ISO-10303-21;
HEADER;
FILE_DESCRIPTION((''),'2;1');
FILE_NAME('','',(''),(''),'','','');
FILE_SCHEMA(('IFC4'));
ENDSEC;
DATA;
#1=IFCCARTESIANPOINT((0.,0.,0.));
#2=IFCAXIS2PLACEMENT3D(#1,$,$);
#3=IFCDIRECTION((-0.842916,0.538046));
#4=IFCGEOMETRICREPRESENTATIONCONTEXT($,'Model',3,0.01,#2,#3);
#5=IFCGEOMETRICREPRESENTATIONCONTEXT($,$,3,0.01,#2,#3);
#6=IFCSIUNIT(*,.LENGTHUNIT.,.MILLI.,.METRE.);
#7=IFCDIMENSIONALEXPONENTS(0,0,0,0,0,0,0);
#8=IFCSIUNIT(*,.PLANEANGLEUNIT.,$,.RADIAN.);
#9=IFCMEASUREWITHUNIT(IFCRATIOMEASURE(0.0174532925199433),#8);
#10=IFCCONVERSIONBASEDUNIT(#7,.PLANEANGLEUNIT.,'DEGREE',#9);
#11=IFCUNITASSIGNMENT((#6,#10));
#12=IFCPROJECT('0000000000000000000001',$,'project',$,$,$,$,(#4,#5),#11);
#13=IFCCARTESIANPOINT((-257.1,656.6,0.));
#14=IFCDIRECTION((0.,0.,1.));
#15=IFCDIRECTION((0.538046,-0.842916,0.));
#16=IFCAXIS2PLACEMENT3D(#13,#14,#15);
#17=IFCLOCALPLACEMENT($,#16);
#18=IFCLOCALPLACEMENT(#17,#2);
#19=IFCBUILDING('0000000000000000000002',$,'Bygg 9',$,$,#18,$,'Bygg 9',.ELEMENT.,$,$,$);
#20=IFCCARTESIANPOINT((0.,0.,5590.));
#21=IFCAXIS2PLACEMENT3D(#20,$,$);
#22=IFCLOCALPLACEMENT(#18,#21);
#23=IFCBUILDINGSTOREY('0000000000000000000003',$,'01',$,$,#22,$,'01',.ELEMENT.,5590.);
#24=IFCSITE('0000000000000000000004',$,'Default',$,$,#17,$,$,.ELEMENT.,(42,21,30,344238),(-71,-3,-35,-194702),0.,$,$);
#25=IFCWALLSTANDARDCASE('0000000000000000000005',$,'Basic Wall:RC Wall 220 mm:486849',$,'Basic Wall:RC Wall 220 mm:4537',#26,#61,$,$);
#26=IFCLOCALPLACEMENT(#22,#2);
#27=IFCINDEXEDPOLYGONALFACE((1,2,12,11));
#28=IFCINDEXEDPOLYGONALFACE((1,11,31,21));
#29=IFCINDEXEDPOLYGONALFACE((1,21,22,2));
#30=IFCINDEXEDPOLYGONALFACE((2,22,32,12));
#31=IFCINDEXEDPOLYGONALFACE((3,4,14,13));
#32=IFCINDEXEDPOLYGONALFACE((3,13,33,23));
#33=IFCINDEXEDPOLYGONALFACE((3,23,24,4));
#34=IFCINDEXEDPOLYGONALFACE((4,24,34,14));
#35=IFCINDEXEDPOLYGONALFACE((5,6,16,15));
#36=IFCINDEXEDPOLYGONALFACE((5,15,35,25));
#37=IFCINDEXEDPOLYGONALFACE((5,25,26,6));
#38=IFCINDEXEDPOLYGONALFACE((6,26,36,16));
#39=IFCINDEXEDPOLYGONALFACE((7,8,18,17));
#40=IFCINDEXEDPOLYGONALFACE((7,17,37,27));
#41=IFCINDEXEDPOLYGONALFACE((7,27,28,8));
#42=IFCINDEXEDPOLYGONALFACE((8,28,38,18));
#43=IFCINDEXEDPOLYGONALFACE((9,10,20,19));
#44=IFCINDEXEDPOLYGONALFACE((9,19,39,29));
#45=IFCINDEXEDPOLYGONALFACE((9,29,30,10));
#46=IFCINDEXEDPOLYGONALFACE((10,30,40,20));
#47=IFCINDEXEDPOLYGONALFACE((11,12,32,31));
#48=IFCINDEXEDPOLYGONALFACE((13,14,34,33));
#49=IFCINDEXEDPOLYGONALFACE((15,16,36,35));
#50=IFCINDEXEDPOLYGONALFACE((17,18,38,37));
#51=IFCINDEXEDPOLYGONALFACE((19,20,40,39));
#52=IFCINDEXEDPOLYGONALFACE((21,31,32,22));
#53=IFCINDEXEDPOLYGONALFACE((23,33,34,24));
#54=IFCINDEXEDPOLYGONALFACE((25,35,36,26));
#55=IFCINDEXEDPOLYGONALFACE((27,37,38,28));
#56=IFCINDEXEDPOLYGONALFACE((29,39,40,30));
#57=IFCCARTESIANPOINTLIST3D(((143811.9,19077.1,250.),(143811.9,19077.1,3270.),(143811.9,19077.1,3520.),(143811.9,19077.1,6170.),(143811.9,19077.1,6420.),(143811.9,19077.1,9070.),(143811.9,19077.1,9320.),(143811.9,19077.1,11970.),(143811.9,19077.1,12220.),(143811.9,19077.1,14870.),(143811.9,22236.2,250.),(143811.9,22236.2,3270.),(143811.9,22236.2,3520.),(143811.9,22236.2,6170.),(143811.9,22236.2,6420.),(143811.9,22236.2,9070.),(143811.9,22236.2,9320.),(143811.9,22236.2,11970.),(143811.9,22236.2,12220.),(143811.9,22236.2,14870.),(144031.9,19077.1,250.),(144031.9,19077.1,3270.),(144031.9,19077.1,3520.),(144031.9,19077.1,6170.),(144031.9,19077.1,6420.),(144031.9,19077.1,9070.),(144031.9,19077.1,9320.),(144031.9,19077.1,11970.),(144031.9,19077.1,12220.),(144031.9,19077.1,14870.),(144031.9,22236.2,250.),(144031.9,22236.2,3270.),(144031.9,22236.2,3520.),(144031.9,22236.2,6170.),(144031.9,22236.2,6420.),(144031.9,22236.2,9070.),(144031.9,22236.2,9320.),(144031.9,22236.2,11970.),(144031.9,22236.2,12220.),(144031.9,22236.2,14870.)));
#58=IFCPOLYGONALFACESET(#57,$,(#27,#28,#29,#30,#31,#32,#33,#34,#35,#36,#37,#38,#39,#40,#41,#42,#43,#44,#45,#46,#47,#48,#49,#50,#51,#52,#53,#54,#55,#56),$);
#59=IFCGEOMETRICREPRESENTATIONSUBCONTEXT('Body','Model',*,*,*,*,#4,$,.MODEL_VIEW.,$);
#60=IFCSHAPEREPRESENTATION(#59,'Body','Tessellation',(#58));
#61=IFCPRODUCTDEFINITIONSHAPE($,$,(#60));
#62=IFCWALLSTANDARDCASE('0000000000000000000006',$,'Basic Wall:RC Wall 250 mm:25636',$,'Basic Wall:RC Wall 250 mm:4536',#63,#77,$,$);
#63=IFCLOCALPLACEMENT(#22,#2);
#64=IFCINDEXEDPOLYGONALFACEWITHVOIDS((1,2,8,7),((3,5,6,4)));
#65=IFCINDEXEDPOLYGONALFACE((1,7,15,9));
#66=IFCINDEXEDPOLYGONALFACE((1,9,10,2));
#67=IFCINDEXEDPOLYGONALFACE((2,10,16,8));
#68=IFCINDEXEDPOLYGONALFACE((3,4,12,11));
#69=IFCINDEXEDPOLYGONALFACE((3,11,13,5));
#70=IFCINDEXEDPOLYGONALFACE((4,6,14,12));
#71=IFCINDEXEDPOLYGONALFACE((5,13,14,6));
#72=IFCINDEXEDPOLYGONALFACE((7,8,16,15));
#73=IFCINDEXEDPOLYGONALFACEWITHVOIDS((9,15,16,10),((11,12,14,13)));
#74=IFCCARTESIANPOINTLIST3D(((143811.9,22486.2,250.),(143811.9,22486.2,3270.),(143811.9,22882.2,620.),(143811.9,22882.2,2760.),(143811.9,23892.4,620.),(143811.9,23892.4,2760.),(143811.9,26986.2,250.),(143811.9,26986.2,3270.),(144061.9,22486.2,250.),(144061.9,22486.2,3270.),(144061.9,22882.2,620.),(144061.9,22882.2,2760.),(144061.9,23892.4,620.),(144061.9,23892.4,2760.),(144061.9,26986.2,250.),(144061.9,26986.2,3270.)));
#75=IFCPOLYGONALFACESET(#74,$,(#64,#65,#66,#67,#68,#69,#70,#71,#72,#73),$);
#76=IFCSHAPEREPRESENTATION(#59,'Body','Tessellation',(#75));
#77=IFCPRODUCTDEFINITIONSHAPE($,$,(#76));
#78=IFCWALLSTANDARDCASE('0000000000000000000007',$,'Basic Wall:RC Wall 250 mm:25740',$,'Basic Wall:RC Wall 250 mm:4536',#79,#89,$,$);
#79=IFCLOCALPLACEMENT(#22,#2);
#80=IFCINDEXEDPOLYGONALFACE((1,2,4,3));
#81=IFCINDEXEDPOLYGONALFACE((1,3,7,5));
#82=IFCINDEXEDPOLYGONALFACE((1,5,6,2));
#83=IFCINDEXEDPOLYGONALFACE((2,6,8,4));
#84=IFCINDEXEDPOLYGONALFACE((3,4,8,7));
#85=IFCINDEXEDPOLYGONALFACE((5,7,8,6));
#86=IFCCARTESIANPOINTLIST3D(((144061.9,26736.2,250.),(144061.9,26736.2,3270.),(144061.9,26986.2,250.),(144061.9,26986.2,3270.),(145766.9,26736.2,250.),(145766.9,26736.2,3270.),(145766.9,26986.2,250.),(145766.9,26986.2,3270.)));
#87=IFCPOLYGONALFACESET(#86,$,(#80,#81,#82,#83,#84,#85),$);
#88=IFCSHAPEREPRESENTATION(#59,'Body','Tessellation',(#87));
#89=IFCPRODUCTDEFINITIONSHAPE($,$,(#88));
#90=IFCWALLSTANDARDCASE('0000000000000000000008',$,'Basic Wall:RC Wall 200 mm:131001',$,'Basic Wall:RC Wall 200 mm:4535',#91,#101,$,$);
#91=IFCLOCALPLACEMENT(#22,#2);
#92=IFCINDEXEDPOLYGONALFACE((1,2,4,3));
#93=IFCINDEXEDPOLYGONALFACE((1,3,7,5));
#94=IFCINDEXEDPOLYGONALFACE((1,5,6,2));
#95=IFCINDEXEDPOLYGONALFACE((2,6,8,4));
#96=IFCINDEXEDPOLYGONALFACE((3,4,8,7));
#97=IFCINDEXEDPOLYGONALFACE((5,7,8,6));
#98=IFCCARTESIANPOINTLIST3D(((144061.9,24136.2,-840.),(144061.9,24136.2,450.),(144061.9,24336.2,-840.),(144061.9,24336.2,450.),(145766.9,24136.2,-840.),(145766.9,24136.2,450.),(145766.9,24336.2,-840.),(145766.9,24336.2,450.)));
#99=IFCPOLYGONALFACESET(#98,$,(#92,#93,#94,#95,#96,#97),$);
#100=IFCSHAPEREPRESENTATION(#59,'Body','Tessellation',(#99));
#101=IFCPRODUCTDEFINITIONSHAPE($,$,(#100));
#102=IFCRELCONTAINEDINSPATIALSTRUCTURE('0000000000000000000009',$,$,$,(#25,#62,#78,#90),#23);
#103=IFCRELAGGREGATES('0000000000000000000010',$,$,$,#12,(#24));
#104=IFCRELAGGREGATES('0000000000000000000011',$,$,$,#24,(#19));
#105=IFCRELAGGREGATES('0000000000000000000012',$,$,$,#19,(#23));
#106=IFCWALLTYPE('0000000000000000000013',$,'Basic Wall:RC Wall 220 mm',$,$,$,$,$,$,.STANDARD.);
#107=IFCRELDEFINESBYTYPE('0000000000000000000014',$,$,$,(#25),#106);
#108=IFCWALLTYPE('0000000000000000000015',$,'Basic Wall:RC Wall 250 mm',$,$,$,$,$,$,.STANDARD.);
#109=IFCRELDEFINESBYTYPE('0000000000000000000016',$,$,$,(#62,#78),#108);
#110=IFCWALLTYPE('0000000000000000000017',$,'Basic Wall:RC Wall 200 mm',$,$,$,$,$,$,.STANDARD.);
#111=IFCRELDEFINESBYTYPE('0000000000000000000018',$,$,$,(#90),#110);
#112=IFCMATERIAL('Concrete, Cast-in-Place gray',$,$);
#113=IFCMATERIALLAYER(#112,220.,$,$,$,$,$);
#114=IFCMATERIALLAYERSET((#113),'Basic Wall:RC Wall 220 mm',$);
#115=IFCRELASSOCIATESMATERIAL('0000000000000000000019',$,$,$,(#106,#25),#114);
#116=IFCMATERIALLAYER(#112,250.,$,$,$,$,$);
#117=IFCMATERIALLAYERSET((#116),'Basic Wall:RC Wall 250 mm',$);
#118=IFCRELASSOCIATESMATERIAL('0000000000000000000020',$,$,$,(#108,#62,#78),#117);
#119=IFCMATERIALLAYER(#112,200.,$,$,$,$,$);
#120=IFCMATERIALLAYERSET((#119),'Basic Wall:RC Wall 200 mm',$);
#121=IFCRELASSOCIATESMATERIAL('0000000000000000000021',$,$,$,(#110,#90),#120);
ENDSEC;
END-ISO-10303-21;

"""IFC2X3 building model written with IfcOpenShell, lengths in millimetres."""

from ifc_helpers import new_model, entity, si_unit, converted_unit, direction, frame, frame_2d, origin, origin_2d_with_axis, place, context, subcontext, project, spatial, polyline, rectangle, extrude, clip, bounded_halfspace, material, layer, layer_set, layer_usage, type_object, element, save


model = new_model("IFC2X3")

# Units and contexts
model_context = context("Model", 3, precision=0.01, world=origin(), true_north=direction((-0.842916, 0.538046)))
context_of_model = context(None, 3, precision=0.01, world=origin(), true_north=direction((-0.842916, 0.538046)))
body_context = subcontext(model_context, "Body", "Model", "MODEL_VIEW")
ifc_project = project(units=[si_unit("LENGTHUNIT", "METRE", prefix="MILLI"), converted_unit("PLANEANGLEUNIT", "DEGREE", entity("IfcRatioMeasure", 0.0174532925199433), si_unit("PLANEANGLEUNIT", "RADIAN"), dimensions=[0, 0, 0, 0, 0, 0, 0])], contexts=[model_context, context_of_model])

# Site, building, storey
site_placement = place(None, frame((-257.1, 656.6, 0.0), z_axis=(0.0, 0.0, 1.0), x_axis=(0.538046, -0.842916, 0.0)))
site = spatial("IfcSite", under=ifc_project, at=site_placement, Name="Default", CompositionType="ELEMENT", RefLatitude=(42, 21, 30, 344238), RefLongitude=(-71, -3, -35, -194702), RefElevation=0.0)
building_placement = place(site_placement, origin())
building = spatial("IfcBuilding", under=site, at=building_placement, Name="Bygg 9", LongName="Bygg 9", CompositionType="ELEMENT")
storey_placement = place(building_placement, frame((0.0, 0.0, 5590.0)))
storey = spatial("IfcBuildingStorey", under=building, at=storey_placement, Name="01", LongName="01", CompositionType="ELEMENT", Elevation=5590.0)

# Shared definitions
ifc_material_1 = material(Name="Concrete, Cast-in-Place gray")

# Wall, openings
ifc_layer_1 = layer(ifc_material_1, 220.0)
ifc_layer_set_1 = layer_set([ifc_layer_1], Name="Basic Wall:RC Wall 220 mm")
wall_type_1 = type_object("IfcWallType", Name="Basic Wall:RC Wall 220 mm", PredefinedType="STANDARD", material=ifc_layer_set_1)
ifc_layer_usage_1 = layer_usage(ifc_layer_set_1, "AXIS2", "NEGATIVE", 110.0)
wall_1_placement = place(storey_placement, frame((143921.9, 19077.1, 250.0), z_axis=(0.0, 0.0, 1.0), x_axis=(0.0, 1.0, 0.0)))
wall_1 = element("IfcWallStandardCase", 1, at=wall_1_placement, inside=storey, type_object=wall_type_1, material=ifc_layer_usage_1, Name="Basic Wall:RC Wall 220 mm:486849", ObjectType="Basic Wall:RC Wall 220 mm:4537", context=body_context, shape_type="Clipping", body=[
    clip(extrude(rectangle(XDim=3159.1, YDim=220.0, at=frame_2d((1579.5, 0.0), x_axis=(-1.0, 0.0))), origin(), (0.0, 0.0, 1.0), 14620.0), bounded_halfspace(frame((848.0, -110.0, 14620.0), z_axis=(0.0, 0.0, -1.0), x_axis=(0.99571, 0.092527, 0.0)), True, frame((848.0, -110.0, 14620.0)), polyline([(0.0, 0.0), (2311.0, 0.0), (2311.0, 220.0), (0.0, 220.0), (-848.0, 220.0), (-848.0, 128.9), (0.0, 128.9), (0.0, 0.0)]))),
])
opening_1_placement = place(storey_placement, frame((143921.9, 19077.1, 250.0), z_axis=(0.0, 0.0, 1.0), x_axis=(0.0, 1.0, 0.0)))
element("IfcOpeningElement", 2, at=opening_1_placement, cuts=wall_1, ObjectType="Opening", context=body_context, shape_type="SweptSolid", body=[
    extrude(rectangle(XDim=3159.1, YDim=220.0, at=frame_2d((0.0, 0.0), x_axis=(1.0, 0.0))), frame((1579.5, 0.0, 3020.0)), (0.0, 0.0, 1.0), 250.0),
])
opening_2_placement = place(storey_placement, frame((143921.9, 19077.1, 250.0), z_axis=(0.0, 0.0, 1.0), x_axis=(0.0, 1.0, 0.0)))
element("IfcOpeningElement", 3, at=opening_2_placement, cuts=wall_1, ObjectType="Opening", context=body_context, shape_type="SweptSolid", body=[
    extrude(rectangle(XDim=3159.1, YDim=220.0, at=frame_2d((0.0, 0.0), x_axis=(1.0, 0.0))), frame((1579.5, 0.0, 5920.0)), (0.0, 0.0, 1.0), 250.0),
])
opening_3_placement = place(storey_placement, frame((143921.9, 19077.1, 250.0), z_axis=(0.0, 0.0, 1.0), x_axis=(0.0, 1.0, 0.0)))
element("IfcOpeningElement", 4, at=opening_3_placement, cuts=wall_1, ObjectType="Opening", context=body_context, shape_type="SweptSolid", body=[
    extrude(rectangle(XDim=3159.1, YDim=220.0, at=frame_2d((0.0, 0.0), x_axis=(1.0, 0.0))), frame((1579.5, 0.0, 8820.0)), (0.0, 0.0, 1.0), 250.0),
])
opening_4_placement = place(storey_placement, frame((143921.9, 19077.1, 250.0), z_axis=(0.0, 0.0, 1.0), x_axis=(0.0, 1.0, 0.0)))
element("IfcOpeningElement", 5, at=opening_4_placement, cuts=wall_1, ObjectType="Opening", context=body_context, shape_type="SweptSolid", body=[
    extrude(rectangle(XDim=3159.1, YDim=220.0, at=frame_2d((0.0, 0.0), x_axis=(1.0, 0.0))), frame((1579.5, 0.0, 11720.0)), (0.0, 0.0, 1.0), 250.0),
])
ifc_layer_2 = layer(ifc_material_1, 250.0)
ifc_layer_set_2 = layer_set([ifc_layer_2], Name="Basic Wall:RC Wall 250 mm")
wall_type_2 = type_object("IfcWallType", Name="Basic Wall:RC Wall 250 mm", PredefinedType="STANDARD", material=ifc_layer_set_2)

# Wall, opening
ifc_layer_usage_2 = layer_usage(ifc_layer_set_2, "AXIS2", "NEGATIVE", 125.0)
wall_2_placement = place(storey_placement, frame((143936.9, 22486.2, 250.0), z_axis=(0.0, 0.0, 1.0), x_axis=(0.0, 1.0, 0.0)))
wall_2 = element("IfcWallStandardCase", 6, at=wall_2_placement, inside=storey, type_object=wall_type_2, material=ifc_layer_usage_2, Name="Basic Wall:RC Wall 250 mm:25636", ObjectType="Basic Wall:RC Wall 250 mm:4536", context=body_context, shape_type="Clipping", body=[
    clip(clip(extrude(rectangle(XDim=4500.0, YDim=250.0, at=frame_2d((2250.0, 0.0), x_axis=(-1.0, 0.0))), origin(), (0.0, 0.0, 1.0), 3020.0), bounded_halfspace(frame((4500.0, -125.0, 0.0), z_axis=(0.0, 0.0, 1.0), x_axis=(0.0, 1.0, 0.0)), True, frame((4500.0, -125.0, 0.0)), polyline([(0.0, 0.0), (0.0, 250.0), (-4500.0, 250.0), (-4500.0, 0.0), (-250.0, 0.0), (0.0, 0.0)]))), bounded_halfspace(frame((4500.0, 15.0, 3020.0), z_axis=(0.0, 0.0, -1.0), x_axis=(0.0, -1.0, 0.0)), True, frame((4500.0, 15.0, 3020.0)), polyline([(0.0, 0.0), (0.0, 110.0), (-4500.0, 110.0), (-4500.0, 0.0), (-4500.0, -140.0), (-250.0, -140.0), (0.0, -140.0), (0.0, 0.0)]))),
])
opening_5_placement = place(wall_2_placement, origin())
element("IfcOpeningElement", 7, at=opening_5_placement, cuts=wall_2, ObjectType="Opening", context=body_context, shape_type="SweptSolid", body=[
    extrude(rectangle(XDim=2140.0, YDim=1010.2, at=origin_2d_with_axis()), frame((901.1, -125.0, 1440.0), z_axis=(0.0, 1.0, 0.0), x_axis=(0.0, 0.0, -1.0)), (0.0, 0.0, 1.0), 250.0),
])

# Walls
ifc_layer_usage_3 = layer_usage(ifc_layer_set_2, "AXIS2", "NEGATIVE", 125.0)
wall_3_placement = place(storey_placement, frame((144061.9, 26861.2, 250.0)))
element("IfcWallStandardCase", 8, at=wall_3_placement, inside=storey, type_object=wall_type_2, material=ifc_layer_usage_3, Name="Basic Wall:RC Wall 250 mm:25740", ObjectType="Basic Wall:RC Wall 250 mm:4536", context=body_context, shape_type="Clipping", body=[
    clip(extrude(rectangle(XDim=1705.0, YDim=250.0, at=frame_2d((852.5, 0.0), x_axis=(-1.0, 0.0))), origin(), (0.0, 0.0, 1.0), 3020.0), bounded_halfspace(frame((0.0, -125.0, 3020.0), z_axis=(0.0, 0.0, -1.0), x_axis=(1.0, 0.0, 0.0)), True, frame((0.0, -125.0, 3020.0)), polyline([(0.0, 0.0), (1705.0, 0.0), (1705.0, 250.0), (0.0, 250.0), (0.0, 0.0)]))),
])
ifc_layer_3 = layer(ifc_material_1, 200.0)
ifc_layer_set_3 = layer_set([ifc_layer_3], Name="Basic Wall:RC Wall 200 mm")
ifc_layer_usage_4 = layer_usage(ifc_layer_set_3, "AXIS2", "NEGATIVE", 100.0)
wall_type_3 = type_object("IfcWallType", Name="Basic Wall:RC Wall 200 mm", PredefinedType="STANDARD", material=ifc_layer_set_3)
wall_4_placement = place(storey_placement, frame((145766.9, 24236.2, -840.0), z_axis=(0.0, 0.0, 1.0), x_axis=(-1.0, 0.0, 0.0)))
element("IfcWallStandardCase", 9, at=wall_4_placement, inside=storey, type_object=wall_type_3, material=ifc_layer_usage_4, Name="Basic Wall:RC Wall 200 mm:131001", ObjectType="Basic Wall:RC Wall 200 mm:4535", context=body_context, shape_type="SweptSolid", body=[
    extrude(rectangle(XDim=1705.0, YDim=200.0, at=frame_2d((852.5, 0.0), x_axis=(-1.0, 0.0))), origin(), (0.0, 0.0, 1.0), 1290.0),
])

save(model, "model.ifc")
